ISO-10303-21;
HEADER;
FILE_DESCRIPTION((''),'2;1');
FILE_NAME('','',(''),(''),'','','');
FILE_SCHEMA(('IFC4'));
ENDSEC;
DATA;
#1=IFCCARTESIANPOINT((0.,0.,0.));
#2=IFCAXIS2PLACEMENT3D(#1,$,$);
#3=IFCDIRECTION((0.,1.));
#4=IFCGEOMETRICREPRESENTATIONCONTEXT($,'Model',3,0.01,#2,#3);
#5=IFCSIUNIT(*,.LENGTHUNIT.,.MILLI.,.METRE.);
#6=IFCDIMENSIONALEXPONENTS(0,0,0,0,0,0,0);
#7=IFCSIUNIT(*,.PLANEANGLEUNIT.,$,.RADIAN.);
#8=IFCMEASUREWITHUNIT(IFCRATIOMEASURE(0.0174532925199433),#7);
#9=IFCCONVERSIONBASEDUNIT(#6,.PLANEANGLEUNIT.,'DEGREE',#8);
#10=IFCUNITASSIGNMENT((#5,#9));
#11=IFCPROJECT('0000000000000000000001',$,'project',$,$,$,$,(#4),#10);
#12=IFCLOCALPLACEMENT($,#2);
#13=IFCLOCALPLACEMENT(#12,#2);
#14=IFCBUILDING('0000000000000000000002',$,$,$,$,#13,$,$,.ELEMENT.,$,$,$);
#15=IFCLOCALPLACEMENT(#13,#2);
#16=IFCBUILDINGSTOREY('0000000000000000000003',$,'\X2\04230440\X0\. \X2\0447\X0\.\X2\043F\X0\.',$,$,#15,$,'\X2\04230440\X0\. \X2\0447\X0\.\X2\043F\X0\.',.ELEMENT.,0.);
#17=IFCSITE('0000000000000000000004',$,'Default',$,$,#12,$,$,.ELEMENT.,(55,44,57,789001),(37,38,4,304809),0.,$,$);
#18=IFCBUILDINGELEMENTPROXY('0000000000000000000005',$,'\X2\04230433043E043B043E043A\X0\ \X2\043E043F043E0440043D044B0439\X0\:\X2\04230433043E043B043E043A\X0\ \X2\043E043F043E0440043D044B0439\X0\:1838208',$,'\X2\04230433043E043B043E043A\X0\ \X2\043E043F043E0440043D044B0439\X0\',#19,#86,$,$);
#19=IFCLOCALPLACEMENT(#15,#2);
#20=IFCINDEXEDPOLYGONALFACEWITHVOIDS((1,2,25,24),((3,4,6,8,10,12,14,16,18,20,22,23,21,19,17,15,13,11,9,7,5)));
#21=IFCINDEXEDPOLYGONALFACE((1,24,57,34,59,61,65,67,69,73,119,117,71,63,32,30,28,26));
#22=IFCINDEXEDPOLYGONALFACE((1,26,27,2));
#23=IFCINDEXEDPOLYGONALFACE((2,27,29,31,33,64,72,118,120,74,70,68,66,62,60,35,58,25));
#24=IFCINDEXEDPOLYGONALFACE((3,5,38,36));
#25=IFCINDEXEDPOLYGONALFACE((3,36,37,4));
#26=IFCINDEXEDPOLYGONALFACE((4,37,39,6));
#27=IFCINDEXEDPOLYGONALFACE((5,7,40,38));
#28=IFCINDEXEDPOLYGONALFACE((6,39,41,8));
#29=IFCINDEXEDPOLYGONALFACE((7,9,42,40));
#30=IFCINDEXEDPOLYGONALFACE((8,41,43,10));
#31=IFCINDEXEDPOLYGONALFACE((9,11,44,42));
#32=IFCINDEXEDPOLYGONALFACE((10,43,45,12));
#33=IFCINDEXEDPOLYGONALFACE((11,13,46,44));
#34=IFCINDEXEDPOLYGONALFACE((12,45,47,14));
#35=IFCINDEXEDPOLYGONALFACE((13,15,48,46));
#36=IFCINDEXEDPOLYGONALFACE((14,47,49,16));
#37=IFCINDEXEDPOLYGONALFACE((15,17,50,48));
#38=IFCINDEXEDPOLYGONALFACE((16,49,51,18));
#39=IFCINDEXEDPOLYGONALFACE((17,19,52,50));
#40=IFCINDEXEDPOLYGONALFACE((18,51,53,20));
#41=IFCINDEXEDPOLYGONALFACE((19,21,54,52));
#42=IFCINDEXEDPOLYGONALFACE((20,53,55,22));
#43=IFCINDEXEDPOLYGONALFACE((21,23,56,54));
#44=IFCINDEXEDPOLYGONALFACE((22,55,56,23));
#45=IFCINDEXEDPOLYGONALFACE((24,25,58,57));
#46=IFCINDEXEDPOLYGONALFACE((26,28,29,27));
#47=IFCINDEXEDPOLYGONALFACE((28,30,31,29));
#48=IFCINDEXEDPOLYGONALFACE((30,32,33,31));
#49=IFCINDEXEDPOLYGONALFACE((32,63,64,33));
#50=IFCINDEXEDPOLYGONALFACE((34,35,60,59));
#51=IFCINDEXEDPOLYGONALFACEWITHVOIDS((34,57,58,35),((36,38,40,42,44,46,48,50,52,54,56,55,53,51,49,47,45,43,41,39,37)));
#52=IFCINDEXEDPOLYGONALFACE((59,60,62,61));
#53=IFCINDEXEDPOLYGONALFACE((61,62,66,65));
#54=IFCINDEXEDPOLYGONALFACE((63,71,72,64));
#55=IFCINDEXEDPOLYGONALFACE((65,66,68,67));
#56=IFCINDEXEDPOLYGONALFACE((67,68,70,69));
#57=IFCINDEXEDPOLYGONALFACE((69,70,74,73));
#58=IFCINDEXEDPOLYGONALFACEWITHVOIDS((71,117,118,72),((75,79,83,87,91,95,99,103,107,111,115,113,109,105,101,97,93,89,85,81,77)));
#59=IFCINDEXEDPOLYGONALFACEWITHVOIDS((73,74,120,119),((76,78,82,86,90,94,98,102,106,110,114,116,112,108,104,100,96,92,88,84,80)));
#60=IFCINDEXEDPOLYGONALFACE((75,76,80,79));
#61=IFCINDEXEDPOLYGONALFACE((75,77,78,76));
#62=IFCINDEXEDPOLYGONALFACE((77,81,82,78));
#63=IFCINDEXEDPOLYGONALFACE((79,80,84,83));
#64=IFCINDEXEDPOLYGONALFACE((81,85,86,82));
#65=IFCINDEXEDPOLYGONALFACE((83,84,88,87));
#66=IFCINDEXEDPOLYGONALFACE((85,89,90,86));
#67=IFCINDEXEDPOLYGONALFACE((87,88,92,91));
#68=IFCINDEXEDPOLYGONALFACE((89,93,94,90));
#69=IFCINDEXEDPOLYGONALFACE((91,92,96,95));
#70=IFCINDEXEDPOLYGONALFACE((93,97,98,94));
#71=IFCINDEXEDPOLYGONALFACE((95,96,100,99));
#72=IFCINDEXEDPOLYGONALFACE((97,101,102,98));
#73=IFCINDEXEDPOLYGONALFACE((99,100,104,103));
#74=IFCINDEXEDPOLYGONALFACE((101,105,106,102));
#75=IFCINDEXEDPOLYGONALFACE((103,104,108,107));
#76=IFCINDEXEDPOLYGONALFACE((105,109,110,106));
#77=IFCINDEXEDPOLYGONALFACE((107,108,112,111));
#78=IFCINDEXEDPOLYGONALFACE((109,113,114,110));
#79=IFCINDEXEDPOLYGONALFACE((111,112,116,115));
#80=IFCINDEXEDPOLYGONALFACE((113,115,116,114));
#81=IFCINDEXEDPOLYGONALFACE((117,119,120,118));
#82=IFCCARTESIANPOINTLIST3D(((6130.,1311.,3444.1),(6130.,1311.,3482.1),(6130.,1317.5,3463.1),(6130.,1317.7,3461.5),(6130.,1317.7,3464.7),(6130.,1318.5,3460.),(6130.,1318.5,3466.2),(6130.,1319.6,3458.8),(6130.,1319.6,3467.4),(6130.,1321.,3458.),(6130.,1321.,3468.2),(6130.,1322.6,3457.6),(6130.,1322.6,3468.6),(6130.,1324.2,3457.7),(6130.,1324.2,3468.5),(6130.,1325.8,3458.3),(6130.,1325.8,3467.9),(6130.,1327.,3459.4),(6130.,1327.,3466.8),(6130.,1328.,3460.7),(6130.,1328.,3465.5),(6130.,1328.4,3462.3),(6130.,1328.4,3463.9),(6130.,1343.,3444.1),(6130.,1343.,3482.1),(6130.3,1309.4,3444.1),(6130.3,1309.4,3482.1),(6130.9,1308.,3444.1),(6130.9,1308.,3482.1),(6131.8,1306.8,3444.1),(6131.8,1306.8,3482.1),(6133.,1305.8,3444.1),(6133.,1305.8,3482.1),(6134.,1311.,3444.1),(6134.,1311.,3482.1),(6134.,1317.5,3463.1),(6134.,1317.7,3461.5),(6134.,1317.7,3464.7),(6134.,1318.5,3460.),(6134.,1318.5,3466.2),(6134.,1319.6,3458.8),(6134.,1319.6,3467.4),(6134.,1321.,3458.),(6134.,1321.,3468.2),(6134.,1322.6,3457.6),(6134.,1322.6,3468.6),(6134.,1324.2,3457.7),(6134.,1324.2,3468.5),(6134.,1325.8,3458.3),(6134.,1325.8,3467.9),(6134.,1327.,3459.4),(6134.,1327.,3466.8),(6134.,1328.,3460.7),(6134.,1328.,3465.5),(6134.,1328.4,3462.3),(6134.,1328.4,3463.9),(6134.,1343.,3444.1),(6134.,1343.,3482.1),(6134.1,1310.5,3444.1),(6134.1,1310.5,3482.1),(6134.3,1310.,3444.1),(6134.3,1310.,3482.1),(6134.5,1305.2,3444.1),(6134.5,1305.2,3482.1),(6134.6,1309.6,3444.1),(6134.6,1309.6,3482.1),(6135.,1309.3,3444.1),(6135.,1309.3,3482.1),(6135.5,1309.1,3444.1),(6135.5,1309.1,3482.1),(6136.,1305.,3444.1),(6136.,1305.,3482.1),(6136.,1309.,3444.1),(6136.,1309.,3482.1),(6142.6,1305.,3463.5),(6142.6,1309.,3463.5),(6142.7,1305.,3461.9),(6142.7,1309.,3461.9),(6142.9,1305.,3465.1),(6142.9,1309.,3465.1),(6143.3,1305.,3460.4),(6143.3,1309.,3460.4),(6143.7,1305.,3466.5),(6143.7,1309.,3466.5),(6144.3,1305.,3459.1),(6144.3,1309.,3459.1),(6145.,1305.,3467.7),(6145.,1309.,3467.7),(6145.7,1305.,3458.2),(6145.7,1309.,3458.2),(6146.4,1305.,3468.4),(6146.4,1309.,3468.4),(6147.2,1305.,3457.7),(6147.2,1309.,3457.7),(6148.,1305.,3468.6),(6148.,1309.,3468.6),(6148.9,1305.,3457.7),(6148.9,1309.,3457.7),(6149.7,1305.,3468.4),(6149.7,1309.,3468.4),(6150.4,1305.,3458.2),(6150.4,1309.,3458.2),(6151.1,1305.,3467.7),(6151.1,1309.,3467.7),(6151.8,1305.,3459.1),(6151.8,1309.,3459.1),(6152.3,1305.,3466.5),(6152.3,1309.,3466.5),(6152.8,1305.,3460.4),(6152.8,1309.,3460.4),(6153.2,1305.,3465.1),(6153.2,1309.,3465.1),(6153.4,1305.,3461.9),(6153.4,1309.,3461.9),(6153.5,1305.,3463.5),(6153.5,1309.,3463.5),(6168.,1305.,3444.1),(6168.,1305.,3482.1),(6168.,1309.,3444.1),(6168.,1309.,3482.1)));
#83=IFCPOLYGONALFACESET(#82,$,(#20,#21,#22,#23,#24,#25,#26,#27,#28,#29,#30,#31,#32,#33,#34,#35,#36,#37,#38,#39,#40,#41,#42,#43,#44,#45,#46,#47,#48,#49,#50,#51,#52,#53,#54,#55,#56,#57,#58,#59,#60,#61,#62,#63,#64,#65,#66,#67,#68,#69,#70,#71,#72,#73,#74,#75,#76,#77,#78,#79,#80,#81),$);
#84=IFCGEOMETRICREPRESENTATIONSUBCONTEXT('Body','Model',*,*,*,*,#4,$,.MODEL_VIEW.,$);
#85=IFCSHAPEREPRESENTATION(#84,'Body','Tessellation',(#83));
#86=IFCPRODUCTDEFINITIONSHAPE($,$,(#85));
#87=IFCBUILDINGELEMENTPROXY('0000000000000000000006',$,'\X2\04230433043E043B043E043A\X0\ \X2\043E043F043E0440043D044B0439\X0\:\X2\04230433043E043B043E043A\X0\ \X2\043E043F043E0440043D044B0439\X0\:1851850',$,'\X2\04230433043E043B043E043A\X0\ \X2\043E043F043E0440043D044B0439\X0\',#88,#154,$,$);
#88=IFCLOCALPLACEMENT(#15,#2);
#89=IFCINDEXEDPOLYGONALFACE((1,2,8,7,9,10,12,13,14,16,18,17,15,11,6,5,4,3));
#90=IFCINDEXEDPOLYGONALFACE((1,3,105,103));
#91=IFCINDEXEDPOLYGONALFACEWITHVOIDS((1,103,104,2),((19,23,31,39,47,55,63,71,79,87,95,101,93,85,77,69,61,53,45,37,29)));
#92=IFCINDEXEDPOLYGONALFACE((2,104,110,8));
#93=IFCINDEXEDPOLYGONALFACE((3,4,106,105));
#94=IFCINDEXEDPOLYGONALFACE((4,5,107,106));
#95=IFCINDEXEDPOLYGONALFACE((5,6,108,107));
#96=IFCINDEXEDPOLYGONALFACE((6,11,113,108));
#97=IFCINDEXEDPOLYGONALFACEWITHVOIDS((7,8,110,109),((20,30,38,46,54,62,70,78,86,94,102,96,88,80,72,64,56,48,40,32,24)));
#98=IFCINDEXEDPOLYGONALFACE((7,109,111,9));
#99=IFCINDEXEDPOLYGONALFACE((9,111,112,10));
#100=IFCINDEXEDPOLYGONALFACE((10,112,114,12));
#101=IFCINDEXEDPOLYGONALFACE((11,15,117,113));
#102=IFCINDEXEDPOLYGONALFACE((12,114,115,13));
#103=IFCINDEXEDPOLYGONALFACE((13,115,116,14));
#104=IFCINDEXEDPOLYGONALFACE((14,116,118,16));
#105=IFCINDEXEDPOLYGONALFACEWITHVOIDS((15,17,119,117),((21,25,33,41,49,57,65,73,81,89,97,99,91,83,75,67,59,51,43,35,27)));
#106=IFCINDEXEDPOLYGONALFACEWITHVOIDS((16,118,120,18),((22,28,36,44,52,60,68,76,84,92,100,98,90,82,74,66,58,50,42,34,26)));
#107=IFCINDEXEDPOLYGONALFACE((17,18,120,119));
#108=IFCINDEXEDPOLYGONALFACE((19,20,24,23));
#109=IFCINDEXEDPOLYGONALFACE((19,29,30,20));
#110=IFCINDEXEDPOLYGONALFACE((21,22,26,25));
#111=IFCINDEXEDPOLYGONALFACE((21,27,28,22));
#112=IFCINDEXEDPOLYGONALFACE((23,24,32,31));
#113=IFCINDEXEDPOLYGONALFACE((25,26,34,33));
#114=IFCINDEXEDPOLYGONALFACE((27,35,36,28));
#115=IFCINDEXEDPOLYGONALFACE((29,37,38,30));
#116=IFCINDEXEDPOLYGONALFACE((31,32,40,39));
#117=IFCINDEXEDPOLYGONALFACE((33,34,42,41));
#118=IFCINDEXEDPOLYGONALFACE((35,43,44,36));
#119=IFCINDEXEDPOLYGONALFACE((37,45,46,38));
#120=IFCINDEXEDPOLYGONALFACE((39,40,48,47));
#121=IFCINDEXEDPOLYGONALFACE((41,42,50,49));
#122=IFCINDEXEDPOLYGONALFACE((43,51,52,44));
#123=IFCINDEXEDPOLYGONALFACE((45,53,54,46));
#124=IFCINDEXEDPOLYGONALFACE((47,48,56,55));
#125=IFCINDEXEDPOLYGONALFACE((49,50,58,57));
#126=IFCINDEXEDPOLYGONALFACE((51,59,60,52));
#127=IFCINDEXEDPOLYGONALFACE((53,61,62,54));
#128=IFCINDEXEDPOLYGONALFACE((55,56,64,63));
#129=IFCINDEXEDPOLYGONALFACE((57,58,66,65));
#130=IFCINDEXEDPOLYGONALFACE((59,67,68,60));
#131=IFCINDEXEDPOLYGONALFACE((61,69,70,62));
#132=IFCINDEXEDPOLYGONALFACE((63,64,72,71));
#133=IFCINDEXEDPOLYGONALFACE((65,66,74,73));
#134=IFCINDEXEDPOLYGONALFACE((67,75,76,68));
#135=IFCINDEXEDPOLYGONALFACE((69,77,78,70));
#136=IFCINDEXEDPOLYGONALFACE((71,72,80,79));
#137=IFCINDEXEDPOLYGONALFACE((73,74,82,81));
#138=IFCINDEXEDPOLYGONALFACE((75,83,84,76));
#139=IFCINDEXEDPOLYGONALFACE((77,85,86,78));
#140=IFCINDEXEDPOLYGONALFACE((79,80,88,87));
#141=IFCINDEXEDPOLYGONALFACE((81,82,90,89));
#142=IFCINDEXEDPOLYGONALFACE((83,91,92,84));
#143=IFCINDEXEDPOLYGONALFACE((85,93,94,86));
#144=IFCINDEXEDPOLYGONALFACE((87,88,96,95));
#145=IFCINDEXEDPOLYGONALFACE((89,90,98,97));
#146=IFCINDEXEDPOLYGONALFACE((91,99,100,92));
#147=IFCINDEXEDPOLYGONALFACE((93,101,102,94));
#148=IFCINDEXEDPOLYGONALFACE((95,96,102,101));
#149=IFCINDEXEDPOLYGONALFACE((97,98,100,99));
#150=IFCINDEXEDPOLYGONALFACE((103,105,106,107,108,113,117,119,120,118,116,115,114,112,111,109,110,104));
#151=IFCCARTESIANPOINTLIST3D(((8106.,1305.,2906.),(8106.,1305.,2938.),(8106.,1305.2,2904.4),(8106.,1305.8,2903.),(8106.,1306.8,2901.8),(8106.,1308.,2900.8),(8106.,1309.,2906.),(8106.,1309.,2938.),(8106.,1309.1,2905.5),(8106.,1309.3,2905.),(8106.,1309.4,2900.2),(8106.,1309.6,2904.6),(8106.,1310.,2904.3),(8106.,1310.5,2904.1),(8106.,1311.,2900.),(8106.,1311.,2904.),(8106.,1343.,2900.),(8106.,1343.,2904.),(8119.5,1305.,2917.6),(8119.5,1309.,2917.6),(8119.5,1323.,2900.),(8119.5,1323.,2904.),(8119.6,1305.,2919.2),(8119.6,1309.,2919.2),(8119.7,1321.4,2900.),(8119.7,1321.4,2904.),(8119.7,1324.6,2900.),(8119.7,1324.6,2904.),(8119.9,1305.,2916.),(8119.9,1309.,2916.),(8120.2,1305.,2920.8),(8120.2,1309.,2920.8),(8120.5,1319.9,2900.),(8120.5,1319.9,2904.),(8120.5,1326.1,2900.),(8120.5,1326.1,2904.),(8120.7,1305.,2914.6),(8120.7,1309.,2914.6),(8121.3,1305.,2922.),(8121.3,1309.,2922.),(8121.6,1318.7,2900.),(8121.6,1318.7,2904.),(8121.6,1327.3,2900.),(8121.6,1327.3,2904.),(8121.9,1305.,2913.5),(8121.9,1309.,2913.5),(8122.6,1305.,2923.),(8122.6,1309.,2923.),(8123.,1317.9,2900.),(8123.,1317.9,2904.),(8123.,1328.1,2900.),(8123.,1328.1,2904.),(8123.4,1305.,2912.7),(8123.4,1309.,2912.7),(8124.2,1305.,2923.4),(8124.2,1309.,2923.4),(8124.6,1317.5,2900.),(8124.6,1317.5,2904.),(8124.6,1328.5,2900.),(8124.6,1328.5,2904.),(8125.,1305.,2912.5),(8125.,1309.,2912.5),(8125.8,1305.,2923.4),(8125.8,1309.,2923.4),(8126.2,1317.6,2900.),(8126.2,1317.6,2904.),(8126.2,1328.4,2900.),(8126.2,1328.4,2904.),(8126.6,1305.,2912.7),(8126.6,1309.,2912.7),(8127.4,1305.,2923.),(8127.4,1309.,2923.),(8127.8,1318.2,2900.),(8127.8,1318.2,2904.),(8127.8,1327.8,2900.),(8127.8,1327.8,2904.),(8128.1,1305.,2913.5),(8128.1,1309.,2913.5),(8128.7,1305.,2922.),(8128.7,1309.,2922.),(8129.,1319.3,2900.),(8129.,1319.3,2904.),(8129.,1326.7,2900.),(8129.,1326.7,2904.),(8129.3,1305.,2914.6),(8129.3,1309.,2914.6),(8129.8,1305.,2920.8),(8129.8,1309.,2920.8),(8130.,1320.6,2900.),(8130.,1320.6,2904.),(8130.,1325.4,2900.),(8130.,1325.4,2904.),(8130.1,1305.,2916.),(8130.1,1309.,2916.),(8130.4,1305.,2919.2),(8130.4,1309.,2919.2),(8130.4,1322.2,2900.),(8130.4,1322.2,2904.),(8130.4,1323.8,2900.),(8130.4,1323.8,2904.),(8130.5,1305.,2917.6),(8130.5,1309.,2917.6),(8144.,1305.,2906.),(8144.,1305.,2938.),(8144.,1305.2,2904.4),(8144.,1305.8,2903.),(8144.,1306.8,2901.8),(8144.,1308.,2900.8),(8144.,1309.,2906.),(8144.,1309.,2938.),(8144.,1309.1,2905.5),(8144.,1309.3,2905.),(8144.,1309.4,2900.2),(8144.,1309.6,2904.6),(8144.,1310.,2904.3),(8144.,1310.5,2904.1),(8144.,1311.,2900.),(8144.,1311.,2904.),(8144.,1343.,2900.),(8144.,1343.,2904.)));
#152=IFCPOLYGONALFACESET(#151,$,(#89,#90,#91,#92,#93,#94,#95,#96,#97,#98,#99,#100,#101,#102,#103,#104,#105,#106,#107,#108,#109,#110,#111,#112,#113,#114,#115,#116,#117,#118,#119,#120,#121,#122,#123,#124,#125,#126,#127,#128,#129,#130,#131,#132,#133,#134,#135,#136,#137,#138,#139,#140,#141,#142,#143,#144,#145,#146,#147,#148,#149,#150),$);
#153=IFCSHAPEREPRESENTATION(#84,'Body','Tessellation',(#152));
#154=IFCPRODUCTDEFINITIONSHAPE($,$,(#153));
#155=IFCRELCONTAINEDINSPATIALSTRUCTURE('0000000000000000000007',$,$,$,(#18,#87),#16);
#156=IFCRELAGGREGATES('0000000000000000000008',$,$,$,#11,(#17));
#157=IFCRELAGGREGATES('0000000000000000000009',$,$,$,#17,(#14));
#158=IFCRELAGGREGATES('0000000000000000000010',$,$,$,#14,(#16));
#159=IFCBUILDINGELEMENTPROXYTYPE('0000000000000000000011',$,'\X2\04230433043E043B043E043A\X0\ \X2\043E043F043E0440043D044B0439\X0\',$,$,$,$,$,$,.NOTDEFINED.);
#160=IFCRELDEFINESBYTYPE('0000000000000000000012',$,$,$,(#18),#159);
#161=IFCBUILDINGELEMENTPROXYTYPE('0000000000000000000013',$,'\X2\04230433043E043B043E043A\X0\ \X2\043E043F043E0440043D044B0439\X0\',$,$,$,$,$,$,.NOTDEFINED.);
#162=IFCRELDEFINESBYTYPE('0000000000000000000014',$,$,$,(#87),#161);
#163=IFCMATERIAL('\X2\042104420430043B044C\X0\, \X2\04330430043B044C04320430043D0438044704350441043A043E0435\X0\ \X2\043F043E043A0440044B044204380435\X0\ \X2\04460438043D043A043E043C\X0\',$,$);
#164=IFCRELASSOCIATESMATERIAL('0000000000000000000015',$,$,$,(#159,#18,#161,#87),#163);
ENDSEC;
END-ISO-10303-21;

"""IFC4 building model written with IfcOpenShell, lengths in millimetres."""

from ifc_helpers import new_model, entity, si_unit, converted_unit, direction, frame, frame_2d, origin, place, context, subcontext, project, spatial, polyline, circle_curve, parameter, trimmed, segment, composite_curve, circle, outline, extrude, source, transform, mapped, material, type_object, type_shapes, element, save


model = new_model("IFC4")

# Units and contexts
model_context = context("Model", 3, precision=0.01, world=origin(), true_north=direction((0.0, 1.0)))
body_context = subcontext(model_context, "Body", "Model", "MODEL_VIEW")
ifc_project = project(units=[si_unit("LENGTHUNIT", "METRE", prefix="MILLI"), converted_unit("PLANEANGLEUNIT", "DEGREE", entity("IfcRatioMeasure", 0.0174532925199433), si_unit("PLANEANGLEUNIT", "RADIAN"), dimensions=[0, 0, 0, 0, 0, 0, 0])], contexts=[model_context])

# Site, building, storey
site_placement = place(None, origin())
site = spatial("IfcSite", under=ifc_project, at=site_placement, Name="Default", CompositionType="ELEMENT", RefLatitude=(55, 44, 57, 789001), RefLongitude=(37, 38, 4, 304809), RefElevation=0.0)
building_placement = place(site_placement, origin())
building = spatial("IfcBuilding", under=site, at=building_placement, CompositionType="ELEMENT")
storey_placement = place(building_placement, origin())
storey = spatial("IfcBuildingStorey", under=building, at=storey_placement, Name="Ур. ч.п.", LongName="Ур. ч.п.", CompositionType="ELEMENT", Elevation=0.0)

# Building element proxies, openings
ifc_material_1 = material(Name="Сталь, гальваническое покрытие цинком")
building_element_proxy_type_1 = type_object("IfcBuildingElementProxyType", Name="Уголок опорный", material=ifc_material_1)
shared_shape_1 = source(origin(), body_context, "Body", "SweptSolid", [
    extrude(outline(composite_curve([segment(polyline([(-6.0, -12.0), (26.0, -12.0)]), True, "CONTINUOUS"), segment(polyline([(26.0, -12.0), (26.0, -8.0)]), True, "CONTINUOUS"), segment(polyline([(26.0, -8.0), (-6.0, -8.0)]), True, "CONTINUOUS"), segment(trimmed(circle_curve(frame_2d((-6.0, -6.0), x_axis=(0.0, -1.0)), 2.0), [parameter(270.0)], [parameter(0.0)], True, "PARAMETER"), False, "CONTINUOUS"), segment(polyline([(-8.0, -6.0), (-8.0, 26.0)]), True, "CONTINUOUS"), segment(polyline([(-8.0, 26.0), (-12.0, 26.0)]), True, "CONTINUOUS"), segment(polyline([(-12.0, 26.0), (-12.0, -6.0)]), True, "CONTINUOUS"), segment(trimmed(circle_curve(frame_2d((-6.0, -6.0), x_axis=(0.0, -1.0)), 6.0), [parameter(270.0)], [parameter(360.0)], True, "PARAMETER"), True, "CONTINUOUS")], self_intersect=False)), frame((12.0, -19.0, 12.0), z_axis=(0.0, 1.0, 0.0), x_axis=(0.0, 0.0, 1.0)), (0.0, 0.0, 1.0), 38.0),
])
type_shapes(building_element_proxy_type_1, [shared_shape_1])
proxy_1_placement = place(storey_placement, frame((6130.0, 1305.0, 3463.1), z_axis=(0.0, 1.0, 0.0), x_axis=(1.0, 0.0, 0.0)))
proxy_1 = element("IfcBuildingElementProxy", 1, at=proxy_1_placement, inside=storey, type_object=building_element_proxy_type_1, material=ifc_material_1, Name="Уголок опорный:Уголок опорный:1838208", ObjectType="Уголок опорный", context=body_context, shape_type="MappedRepresentation", body=[
    mapped(shared_shape_1, transform((0.0, 0.0, 0.0), scale=1.0)),
])
opening_1_placement = place(storey_placement, frame((6130.0, 1305.0, 3463.1), z_axis=(0.0, 0.0, -1.0), x_axis=(1.0, 0.0, 0.0)))
element("IfcOpeningElement", 2, at=opening_1_placement, cuts=proxy_1, ObjectType="Opening", PredefinedType="OPENING", context=body_context, shape_type="SweptSolid", body=[
    extrude(circle(Radius=5.5, at=frame_2d((0.0, 0.0), x_axis=(1.0, 0.0))), frame((4.0, -18.0, 0.0), z_axis=(-1.0, 0.0, 0.0), x_axis=(0.0, 1.0, 0.0)), (0.0, 0.0, 1.0), 4.0),
])
opening_2_placement = place(storey_placement, frame((6130.0, 1305.0, 3463.1), z_axis=(0.0, 0.0, -1.0), x_axis=(1.0, 0.0, 0.0)))
element("IfcOpeningElement", 3, at=opening_2_placement, cuts=proxy_1, ObjectType="Opening", PredefinedType="OPENING", context=body_context, shape_type="SweptSolid", body=[
    extrude(circle(Radius=5.5, at=frame_2d((0.0, 0.0), x_axis=(1.0, 0.0))), frame((18.0, 0.0, 0.0), z_axis=(0.0, -1.0, 0.0), x_axis=(0.0, 0.0, -1.0)), (0.0, 0.0, 1.0), 4.0),
])
building_element_proxy_type_2 = type_object("IfcBuildingElementProxyType", Name="Уголок опорный", material=ifc_material_1)
shared_shape_2 = source(origin(), body_context, "Body", "SweptSolid", [
    extrude(outline(composite_curve([segment(polyline([(-6.0, -12.0), (26.0, -12.0)]), True, "CONTINUOUS"), segment(polyline([(26.0, -12.0), (26.0, -8.0)]), True, "CONTINUOUS"), segment(polyline([(26.0, -8.0), (-6.0, -8.0)]), True, "CONTINUOUS"), segment(trimmed(circle_curve(frame_2d((-6.0, -6.0), x_axis=(0.0, -1.0)), 2.0), [parameter(270.0)], [parameter(0.0)], True, "PARAMETER"), False, "CONTINUOUS"), segment(polyline([(-8.0, -6.0), (-8.0, 26.0)]), True, "CONTINUOUS"), segment(polyline([(-8.0, 26.0), (-12.0, 26.0)]), True, "CONTINUOUS"), segment(polyline([(-12.0, 26.0), (-12.0, -6.0)]), True, "CONTINUOUS"), segment(trimmed(circle_curve(frame_2d((-6.0, -6.0), x_axis=(0.0, -1.0)), 6.0), [parameter(270.0)], [parameter(360.0)], True, "PARAMETER"), True, "CONTINUOUS")], self_intersect=False)), frame((12.0, -19.0, 12.0), z_axis=(0.0, 1.0, 0.0), x_axis=(0.0, 0.0, 1.0)), (0.0, 0.0, 1.0), 38.0),
])
type_shapes(building_element_proxy_type_2, [shared_shape_2])
proxy_2_placement = place(storey_placement, frame((8125.0, 1305.0, 2900.0), z_axis=(0.0, 0.0, 1.0), x_axis=(0.0, 1.0, 0.0)))
proxy_2 = element("IfcBuildingElementProxy", 4, at=proxy_2_placement, inside=storey, type_object=building_element_proxy_type_2, material=ifc_material_1, Name="Уголок опорный:Уголок опорный:1851850", ObjectType="Уголок опорный", context=body_context, shape_type="MappedRepresentation", body=[
    mapped(shared_shape_2, transform((0.0, 0.0, 0.0), scale=1.0)),
])
opening_3_placement = place(storey_placement, frame((8125.0, 1305.0, 2900.0), z_axis=(0.0, 0.0, 1.0), x_axis=(-1.0, 0.0, 0.0)))
element("IfcOpeningElement", 5, at=opening_3_placement, cuts=proxy_2, ObjectType="Opening", PredefinedType="OPENING", context=body_context, shape_type="SweptSolid", body=[
    extrude(circle(Radius=5.5, at=frame_2d((0.0, 0.0), x_axis=(1.0, 0.0))), frame((0.0, -4.0, 18.0), z_axis=(0.0, 1.0, 0.0), x_axis=(0.0, 0.0, -1.0)), (0.0, 0.0, 1.0), 4.0),
])
opening_4_placement = place(storey_placement, frame((8125.0, 1305.0, 2900.0), z_axis=(0.0, 0.0, 1.0), x_axis=(-1.0, 0.0, 0.0)))
element("IfcOpeningElement", 6, at=opening_4_placement, cuts=proxy_2, ObjectType="Opening", PredefinedType="OPENING", context=body_context, shape_type="SweptSolid", body=[
    extrude(circle(Radius=5.5, at=frame_2d((0.0, 0.0), x_axis=(1.0, 0.0))), frame((0.0, -18.0, 0.0)), (0.0, 0.0, 1.0), 4.0),
])

save(model, "model.ifc")
